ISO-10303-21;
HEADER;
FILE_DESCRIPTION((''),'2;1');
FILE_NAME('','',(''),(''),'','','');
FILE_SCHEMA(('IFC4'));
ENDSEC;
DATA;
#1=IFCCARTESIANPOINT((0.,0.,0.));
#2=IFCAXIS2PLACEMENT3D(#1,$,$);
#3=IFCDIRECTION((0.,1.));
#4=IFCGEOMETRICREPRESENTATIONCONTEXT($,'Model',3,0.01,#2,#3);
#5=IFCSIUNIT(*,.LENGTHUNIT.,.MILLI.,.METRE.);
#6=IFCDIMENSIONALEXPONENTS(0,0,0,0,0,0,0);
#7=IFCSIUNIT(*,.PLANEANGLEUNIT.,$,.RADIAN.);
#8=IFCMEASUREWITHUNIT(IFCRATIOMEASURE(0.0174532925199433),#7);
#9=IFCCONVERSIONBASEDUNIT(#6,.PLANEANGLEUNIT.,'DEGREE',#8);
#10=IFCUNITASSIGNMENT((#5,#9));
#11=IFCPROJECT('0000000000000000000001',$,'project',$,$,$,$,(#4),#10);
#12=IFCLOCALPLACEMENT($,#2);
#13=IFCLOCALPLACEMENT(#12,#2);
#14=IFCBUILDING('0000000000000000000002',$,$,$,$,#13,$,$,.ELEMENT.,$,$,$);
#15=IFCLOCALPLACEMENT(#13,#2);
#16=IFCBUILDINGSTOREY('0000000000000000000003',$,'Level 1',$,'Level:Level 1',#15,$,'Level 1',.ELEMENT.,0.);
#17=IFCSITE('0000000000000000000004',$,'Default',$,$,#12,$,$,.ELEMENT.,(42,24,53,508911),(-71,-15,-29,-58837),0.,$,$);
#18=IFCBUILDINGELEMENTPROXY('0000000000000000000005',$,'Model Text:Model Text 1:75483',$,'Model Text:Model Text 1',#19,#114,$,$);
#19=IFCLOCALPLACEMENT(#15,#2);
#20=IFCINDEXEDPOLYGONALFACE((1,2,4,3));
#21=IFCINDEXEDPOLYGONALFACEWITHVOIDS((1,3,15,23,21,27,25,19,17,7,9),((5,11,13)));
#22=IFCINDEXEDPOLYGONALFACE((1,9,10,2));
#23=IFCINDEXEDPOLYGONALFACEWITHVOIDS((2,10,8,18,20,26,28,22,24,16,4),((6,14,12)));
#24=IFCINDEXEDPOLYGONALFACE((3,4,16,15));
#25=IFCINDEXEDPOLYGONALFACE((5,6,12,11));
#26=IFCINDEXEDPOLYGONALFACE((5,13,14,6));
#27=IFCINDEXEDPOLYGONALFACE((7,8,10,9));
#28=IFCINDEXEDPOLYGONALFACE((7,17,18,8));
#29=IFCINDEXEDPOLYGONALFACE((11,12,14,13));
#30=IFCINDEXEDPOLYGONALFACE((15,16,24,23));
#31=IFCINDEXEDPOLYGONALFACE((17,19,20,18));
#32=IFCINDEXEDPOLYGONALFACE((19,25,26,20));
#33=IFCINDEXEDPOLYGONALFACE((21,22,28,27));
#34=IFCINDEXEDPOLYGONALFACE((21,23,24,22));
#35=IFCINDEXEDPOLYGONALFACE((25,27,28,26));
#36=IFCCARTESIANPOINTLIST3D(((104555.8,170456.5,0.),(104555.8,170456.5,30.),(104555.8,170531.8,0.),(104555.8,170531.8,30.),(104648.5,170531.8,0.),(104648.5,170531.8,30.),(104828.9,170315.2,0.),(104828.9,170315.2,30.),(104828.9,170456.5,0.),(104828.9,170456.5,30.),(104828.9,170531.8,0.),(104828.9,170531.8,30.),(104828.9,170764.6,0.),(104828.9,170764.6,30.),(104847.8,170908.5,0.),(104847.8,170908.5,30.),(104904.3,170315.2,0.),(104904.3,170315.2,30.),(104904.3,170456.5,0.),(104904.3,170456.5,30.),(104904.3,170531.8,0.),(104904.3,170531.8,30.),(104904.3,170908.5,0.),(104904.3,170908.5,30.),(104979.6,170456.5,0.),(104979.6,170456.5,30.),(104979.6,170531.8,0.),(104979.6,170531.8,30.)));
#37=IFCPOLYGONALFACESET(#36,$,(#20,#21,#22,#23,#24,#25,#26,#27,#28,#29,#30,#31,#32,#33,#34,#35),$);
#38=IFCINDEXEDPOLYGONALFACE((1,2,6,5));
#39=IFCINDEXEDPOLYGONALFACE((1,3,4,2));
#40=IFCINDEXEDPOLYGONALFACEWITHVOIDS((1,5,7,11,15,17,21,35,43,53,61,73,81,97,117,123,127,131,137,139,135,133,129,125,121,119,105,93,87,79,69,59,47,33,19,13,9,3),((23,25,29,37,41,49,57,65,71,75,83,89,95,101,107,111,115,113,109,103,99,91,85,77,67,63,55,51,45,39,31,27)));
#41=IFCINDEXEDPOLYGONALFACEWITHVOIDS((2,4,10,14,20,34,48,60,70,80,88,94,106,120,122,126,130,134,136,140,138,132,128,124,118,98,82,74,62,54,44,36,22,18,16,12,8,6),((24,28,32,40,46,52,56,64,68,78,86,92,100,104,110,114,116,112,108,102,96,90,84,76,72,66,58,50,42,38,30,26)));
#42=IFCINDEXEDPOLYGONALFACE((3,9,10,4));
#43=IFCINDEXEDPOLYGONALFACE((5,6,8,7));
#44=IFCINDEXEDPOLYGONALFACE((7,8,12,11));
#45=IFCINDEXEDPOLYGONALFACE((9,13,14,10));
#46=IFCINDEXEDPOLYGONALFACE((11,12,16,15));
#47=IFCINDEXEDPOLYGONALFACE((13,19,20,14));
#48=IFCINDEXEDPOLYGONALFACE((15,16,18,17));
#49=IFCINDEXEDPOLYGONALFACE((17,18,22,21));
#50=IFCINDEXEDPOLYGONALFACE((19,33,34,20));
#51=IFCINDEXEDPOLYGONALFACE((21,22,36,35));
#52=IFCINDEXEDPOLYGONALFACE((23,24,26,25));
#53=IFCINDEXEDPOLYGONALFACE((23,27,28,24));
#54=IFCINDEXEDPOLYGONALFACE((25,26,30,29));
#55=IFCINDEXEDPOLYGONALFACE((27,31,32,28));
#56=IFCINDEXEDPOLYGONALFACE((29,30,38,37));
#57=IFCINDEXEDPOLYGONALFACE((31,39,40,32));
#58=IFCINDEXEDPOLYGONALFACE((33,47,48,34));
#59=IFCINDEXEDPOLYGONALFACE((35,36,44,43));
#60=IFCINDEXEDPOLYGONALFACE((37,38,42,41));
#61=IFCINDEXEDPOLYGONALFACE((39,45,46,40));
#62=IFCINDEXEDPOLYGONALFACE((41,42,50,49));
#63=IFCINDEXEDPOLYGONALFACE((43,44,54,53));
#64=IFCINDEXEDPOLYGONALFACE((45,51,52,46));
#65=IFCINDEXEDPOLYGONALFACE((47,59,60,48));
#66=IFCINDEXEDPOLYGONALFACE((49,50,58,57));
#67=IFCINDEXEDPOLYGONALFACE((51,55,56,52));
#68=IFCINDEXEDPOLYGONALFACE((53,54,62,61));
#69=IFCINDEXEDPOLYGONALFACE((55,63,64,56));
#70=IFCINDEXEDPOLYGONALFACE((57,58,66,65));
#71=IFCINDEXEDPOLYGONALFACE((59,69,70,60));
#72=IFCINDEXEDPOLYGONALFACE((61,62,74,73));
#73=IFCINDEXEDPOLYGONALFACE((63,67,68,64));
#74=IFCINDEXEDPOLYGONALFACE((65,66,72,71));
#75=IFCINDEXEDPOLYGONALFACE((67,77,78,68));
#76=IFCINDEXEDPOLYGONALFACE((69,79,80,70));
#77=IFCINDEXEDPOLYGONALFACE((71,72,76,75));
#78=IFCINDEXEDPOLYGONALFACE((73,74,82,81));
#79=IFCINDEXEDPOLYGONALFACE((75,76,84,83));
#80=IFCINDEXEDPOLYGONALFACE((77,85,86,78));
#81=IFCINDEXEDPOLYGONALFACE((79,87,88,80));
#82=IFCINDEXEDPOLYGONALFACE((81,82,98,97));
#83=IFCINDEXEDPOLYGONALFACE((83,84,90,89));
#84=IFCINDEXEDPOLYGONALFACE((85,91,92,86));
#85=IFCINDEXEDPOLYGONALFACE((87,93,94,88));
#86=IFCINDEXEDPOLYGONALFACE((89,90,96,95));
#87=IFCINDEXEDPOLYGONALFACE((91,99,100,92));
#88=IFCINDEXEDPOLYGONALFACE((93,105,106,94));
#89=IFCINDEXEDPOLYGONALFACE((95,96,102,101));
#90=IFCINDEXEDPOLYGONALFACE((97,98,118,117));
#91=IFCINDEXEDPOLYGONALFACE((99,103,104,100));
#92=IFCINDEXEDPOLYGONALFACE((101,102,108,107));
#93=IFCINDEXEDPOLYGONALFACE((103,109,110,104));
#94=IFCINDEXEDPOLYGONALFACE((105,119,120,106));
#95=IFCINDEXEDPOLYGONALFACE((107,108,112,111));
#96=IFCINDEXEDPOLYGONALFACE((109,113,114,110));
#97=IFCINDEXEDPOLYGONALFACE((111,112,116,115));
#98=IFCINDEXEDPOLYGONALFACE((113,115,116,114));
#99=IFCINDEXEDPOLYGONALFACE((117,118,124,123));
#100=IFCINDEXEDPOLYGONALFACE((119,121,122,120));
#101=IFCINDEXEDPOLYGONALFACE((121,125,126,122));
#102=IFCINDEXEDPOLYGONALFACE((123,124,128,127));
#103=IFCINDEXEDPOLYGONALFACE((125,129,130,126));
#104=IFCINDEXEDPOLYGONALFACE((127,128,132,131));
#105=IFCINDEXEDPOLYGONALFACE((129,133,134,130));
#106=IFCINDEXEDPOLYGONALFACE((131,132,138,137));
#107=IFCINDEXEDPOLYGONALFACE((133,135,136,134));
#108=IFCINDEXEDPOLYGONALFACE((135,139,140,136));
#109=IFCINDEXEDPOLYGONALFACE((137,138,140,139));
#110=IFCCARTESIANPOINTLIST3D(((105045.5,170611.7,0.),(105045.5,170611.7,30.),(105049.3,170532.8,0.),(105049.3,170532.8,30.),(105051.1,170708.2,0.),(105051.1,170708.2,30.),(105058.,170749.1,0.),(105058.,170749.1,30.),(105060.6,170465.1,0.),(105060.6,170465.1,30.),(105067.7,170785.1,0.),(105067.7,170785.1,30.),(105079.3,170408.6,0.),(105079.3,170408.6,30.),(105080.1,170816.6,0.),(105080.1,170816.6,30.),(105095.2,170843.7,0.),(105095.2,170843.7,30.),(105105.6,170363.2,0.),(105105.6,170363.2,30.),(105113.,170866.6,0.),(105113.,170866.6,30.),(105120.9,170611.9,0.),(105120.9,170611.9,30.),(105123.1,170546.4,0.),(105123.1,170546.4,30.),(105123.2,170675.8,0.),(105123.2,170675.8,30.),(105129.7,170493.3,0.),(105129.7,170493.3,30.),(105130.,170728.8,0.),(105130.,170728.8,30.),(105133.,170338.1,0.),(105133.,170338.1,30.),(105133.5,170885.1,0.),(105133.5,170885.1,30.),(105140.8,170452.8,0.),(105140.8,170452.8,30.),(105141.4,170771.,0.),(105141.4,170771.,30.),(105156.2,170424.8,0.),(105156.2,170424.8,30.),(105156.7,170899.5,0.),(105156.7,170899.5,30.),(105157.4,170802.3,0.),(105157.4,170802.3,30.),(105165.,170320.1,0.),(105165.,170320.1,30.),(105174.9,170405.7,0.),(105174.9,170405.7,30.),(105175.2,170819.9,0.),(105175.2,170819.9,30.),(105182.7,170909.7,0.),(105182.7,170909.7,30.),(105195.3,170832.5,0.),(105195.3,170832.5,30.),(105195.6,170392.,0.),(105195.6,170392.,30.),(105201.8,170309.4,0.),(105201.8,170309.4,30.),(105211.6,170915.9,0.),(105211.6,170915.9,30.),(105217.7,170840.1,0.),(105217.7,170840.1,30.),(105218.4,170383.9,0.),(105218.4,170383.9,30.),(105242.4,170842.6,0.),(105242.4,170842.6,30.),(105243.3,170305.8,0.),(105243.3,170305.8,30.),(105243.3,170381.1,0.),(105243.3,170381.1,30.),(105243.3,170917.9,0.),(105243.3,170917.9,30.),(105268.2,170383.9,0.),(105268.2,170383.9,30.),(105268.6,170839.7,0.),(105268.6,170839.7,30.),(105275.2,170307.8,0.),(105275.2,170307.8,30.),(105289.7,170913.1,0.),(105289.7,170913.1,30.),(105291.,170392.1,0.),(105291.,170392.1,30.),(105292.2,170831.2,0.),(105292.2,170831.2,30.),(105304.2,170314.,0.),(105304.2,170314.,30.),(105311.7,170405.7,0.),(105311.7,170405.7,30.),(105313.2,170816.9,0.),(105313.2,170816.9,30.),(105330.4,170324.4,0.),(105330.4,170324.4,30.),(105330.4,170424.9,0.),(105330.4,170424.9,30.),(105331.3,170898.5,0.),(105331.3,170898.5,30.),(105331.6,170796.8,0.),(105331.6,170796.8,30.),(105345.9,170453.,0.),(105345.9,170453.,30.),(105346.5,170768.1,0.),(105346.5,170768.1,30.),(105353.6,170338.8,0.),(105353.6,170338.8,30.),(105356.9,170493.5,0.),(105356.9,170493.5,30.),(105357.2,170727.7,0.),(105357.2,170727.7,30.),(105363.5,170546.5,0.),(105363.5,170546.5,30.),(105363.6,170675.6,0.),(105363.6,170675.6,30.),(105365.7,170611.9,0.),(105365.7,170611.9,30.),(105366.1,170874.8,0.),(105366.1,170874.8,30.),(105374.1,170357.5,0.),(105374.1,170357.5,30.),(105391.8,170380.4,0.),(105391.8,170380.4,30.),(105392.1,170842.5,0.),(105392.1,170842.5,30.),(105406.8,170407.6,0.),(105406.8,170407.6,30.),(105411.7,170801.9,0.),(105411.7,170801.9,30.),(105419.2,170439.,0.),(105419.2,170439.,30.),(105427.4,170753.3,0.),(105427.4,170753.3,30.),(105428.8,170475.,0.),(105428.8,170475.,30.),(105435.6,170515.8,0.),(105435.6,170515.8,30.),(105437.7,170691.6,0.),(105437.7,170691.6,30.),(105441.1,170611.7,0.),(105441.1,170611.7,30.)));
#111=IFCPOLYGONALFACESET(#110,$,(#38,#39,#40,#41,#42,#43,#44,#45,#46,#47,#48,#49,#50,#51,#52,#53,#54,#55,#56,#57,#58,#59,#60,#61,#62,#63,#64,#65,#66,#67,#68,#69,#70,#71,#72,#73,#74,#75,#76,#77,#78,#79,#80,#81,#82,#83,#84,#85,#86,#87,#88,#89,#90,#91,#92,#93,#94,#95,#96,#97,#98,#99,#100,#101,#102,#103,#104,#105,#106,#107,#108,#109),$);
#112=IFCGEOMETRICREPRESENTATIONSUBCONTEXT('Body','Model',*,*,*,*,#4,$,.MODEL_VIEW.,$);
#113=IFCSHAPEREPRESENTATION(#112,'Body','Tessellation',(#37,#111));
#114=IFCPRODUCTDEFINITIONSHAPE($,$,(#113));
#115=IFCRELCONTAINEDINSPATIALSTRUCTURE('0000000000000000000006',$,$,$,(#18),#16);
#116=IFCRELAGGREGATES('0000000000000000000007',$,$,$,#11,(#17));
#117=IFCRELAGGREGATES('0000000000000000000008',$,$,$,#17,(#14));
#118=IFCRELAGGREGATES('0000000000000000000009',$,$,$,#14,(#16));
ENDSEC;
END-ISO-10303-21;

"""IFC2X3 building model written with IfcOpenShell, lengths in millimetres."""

from ifc_helpers import new_model, entity, si_unit, converted_unit, direction, frame, origin, place, context, subcontext, project, spatial, polyline, outline, extrude, element, save


model = new_model("IFC2X3")

# Units and contexts
model_context = context("Model", 3, precision=0.01, world=origin(), true_north=direction((0.0, 1.0)))
body_context = subcontext(model_context, "Body", "Model", "MODEL_VIEW")
ifc_project = project(units=[si_unit("LENGTHUNIT", "METRE", prefix="MILLI"), converted_unit("PLANEANGLEUNIT", "DEGREE", entity("IfcRatioMeasure", 0.0174532925199433), si_unit("PLANEANGLEUNIT", "RADIAN"), dimensions=[0, 0, 0, 0, 0, 0, 0])], contexts=[model_context])

# Site, building, storey
site_placement = place(None, origin())
site = spatial("IfcSite", under=ifc_project, at=site_placement, Name="Default", CompositionType="ELEMENT", RefLatitude=(42, 24, 53, 508911), RefLongitude=(-71, -15, -29, -58837), RefElevation=0.0)
building_placement = place(site_placement, origin())
building = spatial("IfcBuilding", under=site, at=building_placement, CompositionType="ELEMENT")
storey_placement = place(building_placement, origin())
storey = spatial("IfcBuildingStorey", under=building, at=storey_placement, Name="Level 1", ObjectType="Level:Level 1", LongName="Level 1", CompositionType="ELEMENT", Elevation=0.0)

# Building element proxy
proxy_1_placement = place(storey_placement, origin())
element("IfcBuildingElementProxy", 1, at=proxy_1_placement, inside=storey, Name="Model Text:Model Text 1:75483", ObjectType="Model Text:Model Text 1", context=body_context, shape_type="SweptSolid", body=[
    extrude(outline(polyline([(-6.8, -218.3), (68.5, -218.3), (68.5, -77.1), (143.8, -77.1), (143.8, -1.7), (68.5, -1.7), (68.5, 375.0), (12.0, 375.0), (-280.0, -1.7), (-280.0, -77.1), (-6.8, -77.1), (-6.8, -218.3)]), holes=[polyline([(-6.8, -1.7), (-187.3, -1.7), (-6.8, 231.1), (-6.8, -1.7)])]), frame((104835.8, 170533.5, 0.0)), (0.0, 0.0, 1.0), 30.0),
    extrude(outline(polyline([(-10.6, -198.7), (68.3, -198.7), (136.5, -190.7), (193.9, -174.7), (240.5, -150.6), (266.9, -124.4), (286.3, -93.2), (298.8, -57.0), (304.3, -15.7), (303.8, 16.2), (299.0, 45.5), (289.9, 72.1), (276.6, 96.0), (258.9, 117.3), (236.9, 136.2), (210.4, 152.5), (179.6, 166.3), (144.1, 177.6), (103.7, 186.3), (8.2, 196.4), (-71.8, 196.7), (-134.0, 189.4), (-183.3, 176.1), (-224.7, 158.4), (-258.2, 133.9), (-283.5, 100.3), (-300.1, 59.5), (-307.1, 13.4), (-306.6, -18.4), (-301.8, -47.5), (-292.8, -74.0), (-279.6, -97.9), (-262.0, -119.2), (-240.0, -138.1), (-213.6, -154.5), (-182.8, -168.4), (-147.3, -179.8), (-106.7, -188.6), (-10.6, -198.7)]), holes=[polyline([(-7.2, -123.5), (-71.0, -118.2), (-123.6, -108.8), (-165.2, -95.4), (-195.7, -78.0), (-212.4, -59.4), (-224.1, -38.7), (-230.6, -15.9), (-231.9, 8.9), (-227.8, 35.0), (-218.1, 58.1), (-202.8, 78.4), (-182.0, 95.8), (-152.6, 109.4), (-111.7, 118.1), (-59.4, 122.0), (4.4, 121.1), (69.6, 115.8), (122.2, 106.7), (162.2, 93.7), (189.5, 77.0), (207.7, 57.4), (220.4, 36.0), (227.5, 12.8), (229.1, -12.1), (225.2, -36.8), (215.9, -59.2), (201.3, -79.3), (181.4, -97.1), (152.6, -111.2), (111.6, -120.3), (58.3, -124.4), (-7.2, -123.5)])]), frame((105244.6, 170610.5, 0.0), z_axis=(0.0, 0.0, 1.0), x_axis=(0.047515, -0.998871, 0.0)), (0.0, 0.0, 1.0), 30.0),
])

save(model, "model.ifc")
